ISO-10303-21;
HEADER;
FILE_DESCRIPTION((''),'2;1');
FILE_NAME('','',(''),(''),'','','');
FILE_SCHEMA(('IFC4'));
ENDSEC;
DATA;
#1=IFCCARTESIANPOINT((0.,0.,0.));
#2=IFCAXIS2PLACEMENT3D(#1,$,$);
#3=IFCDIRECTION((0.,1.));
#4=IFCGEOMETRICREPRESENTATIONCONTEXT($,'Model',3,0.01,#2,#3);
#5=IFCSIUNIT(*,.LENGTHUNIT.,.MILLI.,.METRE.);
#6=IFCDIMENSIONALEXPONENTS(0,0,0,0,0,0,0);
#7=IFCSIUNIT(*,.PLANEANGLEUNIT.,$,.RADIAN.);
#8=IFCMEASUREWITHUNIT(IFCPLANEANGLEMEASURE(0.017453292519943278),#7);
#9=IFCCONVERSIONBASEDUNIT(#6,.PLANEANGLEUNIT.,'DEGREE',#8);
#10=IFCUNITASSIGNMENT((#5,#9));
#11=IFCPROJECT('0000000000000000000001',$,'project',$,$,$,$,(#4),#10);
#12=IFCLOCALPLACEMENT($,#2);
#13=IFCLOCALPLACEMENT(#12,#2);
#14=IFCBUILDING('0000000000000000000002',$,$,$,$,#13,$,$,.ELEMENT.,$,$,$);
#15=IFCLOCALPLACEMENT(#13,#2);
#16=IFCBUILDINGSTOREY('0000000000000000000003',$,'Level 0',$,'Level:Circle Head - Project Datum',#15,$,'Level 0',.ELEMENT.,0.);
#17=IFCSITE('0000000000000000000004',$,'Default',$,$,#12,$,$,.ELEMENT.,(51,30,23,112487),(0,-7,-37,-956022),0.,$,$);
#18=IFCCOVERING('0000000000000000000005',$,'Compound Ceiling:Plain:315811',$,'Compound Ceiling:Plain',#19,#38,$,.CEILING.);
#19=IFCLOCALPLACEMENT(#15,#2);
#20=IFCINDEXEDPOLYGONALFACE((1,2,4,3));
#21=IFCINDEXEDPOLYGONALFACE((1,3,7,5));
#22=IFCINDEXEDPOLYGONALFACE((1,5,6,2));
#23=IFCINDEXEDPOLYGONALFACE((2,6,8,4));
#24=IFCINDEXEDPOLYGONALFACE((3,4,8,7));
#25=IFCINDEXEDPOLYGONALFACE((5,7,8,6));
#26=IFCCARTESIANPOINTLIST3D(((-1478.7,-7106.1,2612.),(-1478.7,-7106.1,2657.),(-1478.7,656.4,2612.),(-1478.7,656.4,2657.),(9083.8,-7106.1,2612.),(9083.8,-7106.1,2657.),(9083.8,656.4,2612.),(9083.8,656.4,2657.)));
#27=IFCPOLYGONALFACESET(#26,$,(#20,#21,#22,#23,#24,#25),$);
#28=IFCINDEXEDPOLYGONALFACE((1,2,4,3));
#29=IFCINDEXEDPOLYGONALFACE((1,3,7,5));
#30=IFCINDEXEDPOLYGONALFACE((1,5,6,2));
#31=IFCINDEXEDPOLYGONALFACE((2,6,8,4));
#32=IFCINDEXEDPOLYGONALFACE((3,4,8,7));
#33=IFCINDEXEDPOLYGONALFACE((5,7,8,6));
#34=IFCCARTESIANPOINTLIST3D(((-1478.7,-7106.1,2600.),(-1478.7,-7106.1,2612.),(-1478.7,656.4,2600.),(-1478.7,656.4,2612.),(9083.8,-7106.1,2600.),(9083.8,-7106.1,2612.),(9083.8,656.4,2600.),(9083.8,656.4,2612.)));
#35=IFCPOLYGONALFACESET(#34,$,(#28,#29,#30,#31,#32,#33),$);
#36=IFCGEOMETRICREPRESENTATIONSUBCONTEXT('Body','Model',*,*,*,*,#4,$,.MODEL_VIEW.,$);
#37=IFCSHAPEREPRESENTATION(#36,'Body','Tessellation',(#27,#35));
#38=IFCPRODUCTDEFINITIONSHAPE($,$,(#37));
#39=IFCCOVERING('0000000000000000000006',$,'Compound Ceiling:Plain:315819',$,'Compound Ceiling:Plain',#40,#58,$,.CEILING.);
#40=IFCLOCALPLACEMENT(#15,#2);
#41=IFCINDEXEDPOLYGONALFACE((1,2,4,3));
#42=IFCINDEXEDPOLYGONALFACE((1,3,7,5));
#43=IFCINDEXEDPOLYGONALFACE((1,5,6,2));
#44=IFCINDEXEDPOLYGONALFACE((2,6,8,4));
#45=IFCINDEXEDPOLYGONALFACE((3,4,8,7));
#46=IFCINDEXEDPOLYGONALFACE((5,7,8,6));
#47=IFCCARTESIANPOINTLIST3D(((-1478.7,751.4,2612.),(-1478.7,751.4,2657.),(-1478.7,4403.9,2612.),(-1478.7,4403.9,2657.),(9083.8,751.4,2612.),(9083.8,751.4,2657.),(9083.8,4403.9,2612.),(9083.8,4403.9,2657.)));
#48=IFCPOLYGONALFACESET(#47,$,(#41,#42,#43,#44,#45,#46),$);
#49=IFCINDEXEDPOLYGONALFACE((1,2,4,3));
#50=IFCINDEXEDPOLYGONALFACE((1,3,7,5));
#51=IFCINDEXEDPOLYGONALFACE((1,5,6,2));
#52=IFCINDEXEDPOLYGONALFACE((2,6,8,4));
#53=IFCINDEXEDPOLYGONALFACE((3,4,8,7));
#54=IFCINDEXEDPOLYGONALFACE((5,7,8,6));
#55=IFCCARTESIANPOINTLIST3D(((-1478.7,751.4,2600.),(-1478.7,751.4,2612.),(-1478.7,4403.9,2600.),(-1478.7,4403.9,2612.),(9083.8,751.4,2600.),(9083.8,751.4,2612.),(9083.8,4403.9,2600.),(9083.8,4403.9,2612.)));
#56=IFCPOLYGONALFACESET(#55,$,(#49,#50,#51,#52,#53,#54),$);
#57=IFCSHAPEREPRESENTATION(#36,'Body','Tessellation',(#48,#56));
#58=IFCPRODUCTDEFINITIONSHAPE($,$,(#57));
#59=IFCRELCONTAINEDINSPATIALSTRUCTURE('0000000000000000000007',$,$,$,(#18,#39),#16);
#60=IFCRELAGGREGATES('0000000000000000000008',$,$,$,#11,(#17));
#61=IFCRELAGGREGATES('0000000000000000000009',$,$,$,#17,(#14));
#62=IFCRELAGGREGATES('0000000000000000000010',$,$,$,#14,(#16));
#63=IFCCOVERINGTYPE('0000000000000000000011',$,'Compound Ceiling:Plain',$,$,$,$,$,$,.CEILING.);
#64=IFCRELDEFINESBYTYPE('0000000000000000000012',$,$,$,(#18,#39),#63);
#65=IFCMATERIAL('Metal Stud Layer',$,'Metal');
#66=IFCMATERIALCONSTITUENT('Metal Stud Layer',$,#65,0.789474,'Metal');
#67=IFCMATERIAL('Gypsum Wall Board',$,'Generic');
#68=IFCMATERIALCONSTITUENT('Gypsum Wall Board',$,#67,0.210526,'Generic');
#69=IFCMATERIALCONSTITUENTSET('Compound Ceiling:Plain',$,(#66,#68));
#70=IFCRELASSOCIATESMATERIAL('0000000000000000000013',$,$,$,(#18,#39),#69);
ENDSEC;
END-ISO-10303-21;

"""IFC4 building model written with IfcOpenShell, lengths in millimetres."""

from ifc_helpers import new_model, entity, si_unit, converted_unit, direction, frame, origin, place, context, subcontext, project, spatial, indexed_curve, outline, extrude, material, constituent, constituent_set, type_object, element, save


model = new_model("IFC4")

# Units and contexts
model_context = context("Model", 3, precision=0.01, world=origin(), true_north=direction((0.0, 1.0)))
body_context = subcontext(model_context, "Body", "Model", "MODEL_VIEW")
ifc_project = project(units=[si_unit("LENGTHUNIT", "METRE", prefix="MILLI"), converted_unit("PLANEANGLEUNIT", "DEGREE", entity("IfcPlaneAngleMeasure", 0.017453292519943278), si_unit("PLANEANGLEUNIT", "RADIAN"), dimensions=[0, 0, 0, 0, 0, 0, 0])], contexts=[model_context])

# Site, building, storey
site_placement = place(None, origin())
site = spatial("IfcSite", under=ifc_project, at=site_placement, Name="Default", CompositionType="ELEMENT", RefLatitude=(51, 30, 23, 112487), RefLongitude=(0, -7, -37, -956022), RefElevation=0.0)
building_placement = place(site_placement, origin())
building = spatial("IfcBuilding", under=site, at=building_placement, CompositionType="ELEMENT")
storey_placement = place(building_placement, origin())
storey = spatial("IfcBuildingStorey", under=building, at=storey_placement, Name="Level 0", ObjectType="Level:Circle Head - Project Datum", LongName="Level 0", CompositionType="ELEMENT", Elevation=0.0)

# Shared definitions
ifc_material_1 = material(Name="Metal Stud Layer", Category="Metal")

# Coverings
ifc_constituent_1 = constituent(ifc_material_1, Name="Metal Stud Layer", Category="Metal", fraction=0.789474)
ifc_material_2 = material(Name="Gypsum Wall Board", Category="Generic")
ifc_constituent_2 = constituent(ifc_material_2, Name="Gypsum Wall Board", Category="Generic", fraction=0.210526)
ifc_constituent_set_1 = constituent_set(constituents=[ifc_constituent_1, ifc_constituent_2], Name="Compound Ceiling:Plain")
covering_type = type_object("IfcCoveringType", Name="Compound Ceiling:Plain", PredefinedType="CEILING")
covering_1_placement = place(storey_placement, origin())
element("IfcCovering", 1, at=covering_1_placement, inside=storey, type_object=covering_type, material=ifc_constituent_set_1, Name="Compound Ceiling:Plain:315811", ObjectType="Compound Ceiling:Plain", PredefinedType="CEILING", context=body_context, shape_type="SweptSolid", body=[
    extrude(outline(indexed_curve([(-3881.2, -5281.2), (3881.2, -5281.2), (3881.2, 5281.2), (-3881.2, 5281.2), (-3881.2, -5281.2)], self_intersect=False)), frame((3802.5, -3224.8, 2612.0), z_axis=(0.0, 0.0, 1.0), x_axis=(0.0, -1.0, 0.0)), (0.0, 0.0, 1.0), 45.0),
    extrude(outline(indexed_curve([(-5281.2, -3881.2), (5281.3, -3881.2), (5281.2, 3881.3), (-5281.3, 3881.2), (-5281.2, -3881.2)], self_intersect=False)), frame((3802.5, -3224.8, 2600.0), z_axis=(0.0, 0.0, 1.0), x_axis=(-1.0, 0.0, 0.0)), (0.0, 0.0, 1.0), 12.0),
])
covering_2_placement = place(storey_placement, origin())
element("IfcCovering", 2, at=covering_2_placement, inside=storey, type_object=covering_type, material=ifc_constituent_set_1, Name="Compound Ceiling:Plain:315819", ObjectType="Compound Ceiling:Plain", PredefinedType="CEILING", context=body_context, shape_type="SweptSolid", body=[
    extrude(outline(indexed_curve([(-5281.2, -1826.3), (5281.3, -1826.3), (5281.2, 1826.3), (-5281.3, 1826.3), (-5281.2, -1826.3)], self_intersect=False)), frame((3802.5, 2577.7, 2612.0)), (0.0, 0.0, 1.0), 45.0),
    extrude(outline(indexed_curve([(-1826.3, -5281.2), (1826.2, -5281.2), (1826.3, 5281.2), (-1826.2, 5281.2), (-1826.3, -5281.2)], self_intersect=False)), frame((3802.5, 2577.7, 2600.0), z_axis=(0.0, 0.0, 1.0), x_axis=(0.0, -1.0, 0.0)), (0.0, 0.0, 1.0), 12.0),
])

save(model, "model.ifc")
